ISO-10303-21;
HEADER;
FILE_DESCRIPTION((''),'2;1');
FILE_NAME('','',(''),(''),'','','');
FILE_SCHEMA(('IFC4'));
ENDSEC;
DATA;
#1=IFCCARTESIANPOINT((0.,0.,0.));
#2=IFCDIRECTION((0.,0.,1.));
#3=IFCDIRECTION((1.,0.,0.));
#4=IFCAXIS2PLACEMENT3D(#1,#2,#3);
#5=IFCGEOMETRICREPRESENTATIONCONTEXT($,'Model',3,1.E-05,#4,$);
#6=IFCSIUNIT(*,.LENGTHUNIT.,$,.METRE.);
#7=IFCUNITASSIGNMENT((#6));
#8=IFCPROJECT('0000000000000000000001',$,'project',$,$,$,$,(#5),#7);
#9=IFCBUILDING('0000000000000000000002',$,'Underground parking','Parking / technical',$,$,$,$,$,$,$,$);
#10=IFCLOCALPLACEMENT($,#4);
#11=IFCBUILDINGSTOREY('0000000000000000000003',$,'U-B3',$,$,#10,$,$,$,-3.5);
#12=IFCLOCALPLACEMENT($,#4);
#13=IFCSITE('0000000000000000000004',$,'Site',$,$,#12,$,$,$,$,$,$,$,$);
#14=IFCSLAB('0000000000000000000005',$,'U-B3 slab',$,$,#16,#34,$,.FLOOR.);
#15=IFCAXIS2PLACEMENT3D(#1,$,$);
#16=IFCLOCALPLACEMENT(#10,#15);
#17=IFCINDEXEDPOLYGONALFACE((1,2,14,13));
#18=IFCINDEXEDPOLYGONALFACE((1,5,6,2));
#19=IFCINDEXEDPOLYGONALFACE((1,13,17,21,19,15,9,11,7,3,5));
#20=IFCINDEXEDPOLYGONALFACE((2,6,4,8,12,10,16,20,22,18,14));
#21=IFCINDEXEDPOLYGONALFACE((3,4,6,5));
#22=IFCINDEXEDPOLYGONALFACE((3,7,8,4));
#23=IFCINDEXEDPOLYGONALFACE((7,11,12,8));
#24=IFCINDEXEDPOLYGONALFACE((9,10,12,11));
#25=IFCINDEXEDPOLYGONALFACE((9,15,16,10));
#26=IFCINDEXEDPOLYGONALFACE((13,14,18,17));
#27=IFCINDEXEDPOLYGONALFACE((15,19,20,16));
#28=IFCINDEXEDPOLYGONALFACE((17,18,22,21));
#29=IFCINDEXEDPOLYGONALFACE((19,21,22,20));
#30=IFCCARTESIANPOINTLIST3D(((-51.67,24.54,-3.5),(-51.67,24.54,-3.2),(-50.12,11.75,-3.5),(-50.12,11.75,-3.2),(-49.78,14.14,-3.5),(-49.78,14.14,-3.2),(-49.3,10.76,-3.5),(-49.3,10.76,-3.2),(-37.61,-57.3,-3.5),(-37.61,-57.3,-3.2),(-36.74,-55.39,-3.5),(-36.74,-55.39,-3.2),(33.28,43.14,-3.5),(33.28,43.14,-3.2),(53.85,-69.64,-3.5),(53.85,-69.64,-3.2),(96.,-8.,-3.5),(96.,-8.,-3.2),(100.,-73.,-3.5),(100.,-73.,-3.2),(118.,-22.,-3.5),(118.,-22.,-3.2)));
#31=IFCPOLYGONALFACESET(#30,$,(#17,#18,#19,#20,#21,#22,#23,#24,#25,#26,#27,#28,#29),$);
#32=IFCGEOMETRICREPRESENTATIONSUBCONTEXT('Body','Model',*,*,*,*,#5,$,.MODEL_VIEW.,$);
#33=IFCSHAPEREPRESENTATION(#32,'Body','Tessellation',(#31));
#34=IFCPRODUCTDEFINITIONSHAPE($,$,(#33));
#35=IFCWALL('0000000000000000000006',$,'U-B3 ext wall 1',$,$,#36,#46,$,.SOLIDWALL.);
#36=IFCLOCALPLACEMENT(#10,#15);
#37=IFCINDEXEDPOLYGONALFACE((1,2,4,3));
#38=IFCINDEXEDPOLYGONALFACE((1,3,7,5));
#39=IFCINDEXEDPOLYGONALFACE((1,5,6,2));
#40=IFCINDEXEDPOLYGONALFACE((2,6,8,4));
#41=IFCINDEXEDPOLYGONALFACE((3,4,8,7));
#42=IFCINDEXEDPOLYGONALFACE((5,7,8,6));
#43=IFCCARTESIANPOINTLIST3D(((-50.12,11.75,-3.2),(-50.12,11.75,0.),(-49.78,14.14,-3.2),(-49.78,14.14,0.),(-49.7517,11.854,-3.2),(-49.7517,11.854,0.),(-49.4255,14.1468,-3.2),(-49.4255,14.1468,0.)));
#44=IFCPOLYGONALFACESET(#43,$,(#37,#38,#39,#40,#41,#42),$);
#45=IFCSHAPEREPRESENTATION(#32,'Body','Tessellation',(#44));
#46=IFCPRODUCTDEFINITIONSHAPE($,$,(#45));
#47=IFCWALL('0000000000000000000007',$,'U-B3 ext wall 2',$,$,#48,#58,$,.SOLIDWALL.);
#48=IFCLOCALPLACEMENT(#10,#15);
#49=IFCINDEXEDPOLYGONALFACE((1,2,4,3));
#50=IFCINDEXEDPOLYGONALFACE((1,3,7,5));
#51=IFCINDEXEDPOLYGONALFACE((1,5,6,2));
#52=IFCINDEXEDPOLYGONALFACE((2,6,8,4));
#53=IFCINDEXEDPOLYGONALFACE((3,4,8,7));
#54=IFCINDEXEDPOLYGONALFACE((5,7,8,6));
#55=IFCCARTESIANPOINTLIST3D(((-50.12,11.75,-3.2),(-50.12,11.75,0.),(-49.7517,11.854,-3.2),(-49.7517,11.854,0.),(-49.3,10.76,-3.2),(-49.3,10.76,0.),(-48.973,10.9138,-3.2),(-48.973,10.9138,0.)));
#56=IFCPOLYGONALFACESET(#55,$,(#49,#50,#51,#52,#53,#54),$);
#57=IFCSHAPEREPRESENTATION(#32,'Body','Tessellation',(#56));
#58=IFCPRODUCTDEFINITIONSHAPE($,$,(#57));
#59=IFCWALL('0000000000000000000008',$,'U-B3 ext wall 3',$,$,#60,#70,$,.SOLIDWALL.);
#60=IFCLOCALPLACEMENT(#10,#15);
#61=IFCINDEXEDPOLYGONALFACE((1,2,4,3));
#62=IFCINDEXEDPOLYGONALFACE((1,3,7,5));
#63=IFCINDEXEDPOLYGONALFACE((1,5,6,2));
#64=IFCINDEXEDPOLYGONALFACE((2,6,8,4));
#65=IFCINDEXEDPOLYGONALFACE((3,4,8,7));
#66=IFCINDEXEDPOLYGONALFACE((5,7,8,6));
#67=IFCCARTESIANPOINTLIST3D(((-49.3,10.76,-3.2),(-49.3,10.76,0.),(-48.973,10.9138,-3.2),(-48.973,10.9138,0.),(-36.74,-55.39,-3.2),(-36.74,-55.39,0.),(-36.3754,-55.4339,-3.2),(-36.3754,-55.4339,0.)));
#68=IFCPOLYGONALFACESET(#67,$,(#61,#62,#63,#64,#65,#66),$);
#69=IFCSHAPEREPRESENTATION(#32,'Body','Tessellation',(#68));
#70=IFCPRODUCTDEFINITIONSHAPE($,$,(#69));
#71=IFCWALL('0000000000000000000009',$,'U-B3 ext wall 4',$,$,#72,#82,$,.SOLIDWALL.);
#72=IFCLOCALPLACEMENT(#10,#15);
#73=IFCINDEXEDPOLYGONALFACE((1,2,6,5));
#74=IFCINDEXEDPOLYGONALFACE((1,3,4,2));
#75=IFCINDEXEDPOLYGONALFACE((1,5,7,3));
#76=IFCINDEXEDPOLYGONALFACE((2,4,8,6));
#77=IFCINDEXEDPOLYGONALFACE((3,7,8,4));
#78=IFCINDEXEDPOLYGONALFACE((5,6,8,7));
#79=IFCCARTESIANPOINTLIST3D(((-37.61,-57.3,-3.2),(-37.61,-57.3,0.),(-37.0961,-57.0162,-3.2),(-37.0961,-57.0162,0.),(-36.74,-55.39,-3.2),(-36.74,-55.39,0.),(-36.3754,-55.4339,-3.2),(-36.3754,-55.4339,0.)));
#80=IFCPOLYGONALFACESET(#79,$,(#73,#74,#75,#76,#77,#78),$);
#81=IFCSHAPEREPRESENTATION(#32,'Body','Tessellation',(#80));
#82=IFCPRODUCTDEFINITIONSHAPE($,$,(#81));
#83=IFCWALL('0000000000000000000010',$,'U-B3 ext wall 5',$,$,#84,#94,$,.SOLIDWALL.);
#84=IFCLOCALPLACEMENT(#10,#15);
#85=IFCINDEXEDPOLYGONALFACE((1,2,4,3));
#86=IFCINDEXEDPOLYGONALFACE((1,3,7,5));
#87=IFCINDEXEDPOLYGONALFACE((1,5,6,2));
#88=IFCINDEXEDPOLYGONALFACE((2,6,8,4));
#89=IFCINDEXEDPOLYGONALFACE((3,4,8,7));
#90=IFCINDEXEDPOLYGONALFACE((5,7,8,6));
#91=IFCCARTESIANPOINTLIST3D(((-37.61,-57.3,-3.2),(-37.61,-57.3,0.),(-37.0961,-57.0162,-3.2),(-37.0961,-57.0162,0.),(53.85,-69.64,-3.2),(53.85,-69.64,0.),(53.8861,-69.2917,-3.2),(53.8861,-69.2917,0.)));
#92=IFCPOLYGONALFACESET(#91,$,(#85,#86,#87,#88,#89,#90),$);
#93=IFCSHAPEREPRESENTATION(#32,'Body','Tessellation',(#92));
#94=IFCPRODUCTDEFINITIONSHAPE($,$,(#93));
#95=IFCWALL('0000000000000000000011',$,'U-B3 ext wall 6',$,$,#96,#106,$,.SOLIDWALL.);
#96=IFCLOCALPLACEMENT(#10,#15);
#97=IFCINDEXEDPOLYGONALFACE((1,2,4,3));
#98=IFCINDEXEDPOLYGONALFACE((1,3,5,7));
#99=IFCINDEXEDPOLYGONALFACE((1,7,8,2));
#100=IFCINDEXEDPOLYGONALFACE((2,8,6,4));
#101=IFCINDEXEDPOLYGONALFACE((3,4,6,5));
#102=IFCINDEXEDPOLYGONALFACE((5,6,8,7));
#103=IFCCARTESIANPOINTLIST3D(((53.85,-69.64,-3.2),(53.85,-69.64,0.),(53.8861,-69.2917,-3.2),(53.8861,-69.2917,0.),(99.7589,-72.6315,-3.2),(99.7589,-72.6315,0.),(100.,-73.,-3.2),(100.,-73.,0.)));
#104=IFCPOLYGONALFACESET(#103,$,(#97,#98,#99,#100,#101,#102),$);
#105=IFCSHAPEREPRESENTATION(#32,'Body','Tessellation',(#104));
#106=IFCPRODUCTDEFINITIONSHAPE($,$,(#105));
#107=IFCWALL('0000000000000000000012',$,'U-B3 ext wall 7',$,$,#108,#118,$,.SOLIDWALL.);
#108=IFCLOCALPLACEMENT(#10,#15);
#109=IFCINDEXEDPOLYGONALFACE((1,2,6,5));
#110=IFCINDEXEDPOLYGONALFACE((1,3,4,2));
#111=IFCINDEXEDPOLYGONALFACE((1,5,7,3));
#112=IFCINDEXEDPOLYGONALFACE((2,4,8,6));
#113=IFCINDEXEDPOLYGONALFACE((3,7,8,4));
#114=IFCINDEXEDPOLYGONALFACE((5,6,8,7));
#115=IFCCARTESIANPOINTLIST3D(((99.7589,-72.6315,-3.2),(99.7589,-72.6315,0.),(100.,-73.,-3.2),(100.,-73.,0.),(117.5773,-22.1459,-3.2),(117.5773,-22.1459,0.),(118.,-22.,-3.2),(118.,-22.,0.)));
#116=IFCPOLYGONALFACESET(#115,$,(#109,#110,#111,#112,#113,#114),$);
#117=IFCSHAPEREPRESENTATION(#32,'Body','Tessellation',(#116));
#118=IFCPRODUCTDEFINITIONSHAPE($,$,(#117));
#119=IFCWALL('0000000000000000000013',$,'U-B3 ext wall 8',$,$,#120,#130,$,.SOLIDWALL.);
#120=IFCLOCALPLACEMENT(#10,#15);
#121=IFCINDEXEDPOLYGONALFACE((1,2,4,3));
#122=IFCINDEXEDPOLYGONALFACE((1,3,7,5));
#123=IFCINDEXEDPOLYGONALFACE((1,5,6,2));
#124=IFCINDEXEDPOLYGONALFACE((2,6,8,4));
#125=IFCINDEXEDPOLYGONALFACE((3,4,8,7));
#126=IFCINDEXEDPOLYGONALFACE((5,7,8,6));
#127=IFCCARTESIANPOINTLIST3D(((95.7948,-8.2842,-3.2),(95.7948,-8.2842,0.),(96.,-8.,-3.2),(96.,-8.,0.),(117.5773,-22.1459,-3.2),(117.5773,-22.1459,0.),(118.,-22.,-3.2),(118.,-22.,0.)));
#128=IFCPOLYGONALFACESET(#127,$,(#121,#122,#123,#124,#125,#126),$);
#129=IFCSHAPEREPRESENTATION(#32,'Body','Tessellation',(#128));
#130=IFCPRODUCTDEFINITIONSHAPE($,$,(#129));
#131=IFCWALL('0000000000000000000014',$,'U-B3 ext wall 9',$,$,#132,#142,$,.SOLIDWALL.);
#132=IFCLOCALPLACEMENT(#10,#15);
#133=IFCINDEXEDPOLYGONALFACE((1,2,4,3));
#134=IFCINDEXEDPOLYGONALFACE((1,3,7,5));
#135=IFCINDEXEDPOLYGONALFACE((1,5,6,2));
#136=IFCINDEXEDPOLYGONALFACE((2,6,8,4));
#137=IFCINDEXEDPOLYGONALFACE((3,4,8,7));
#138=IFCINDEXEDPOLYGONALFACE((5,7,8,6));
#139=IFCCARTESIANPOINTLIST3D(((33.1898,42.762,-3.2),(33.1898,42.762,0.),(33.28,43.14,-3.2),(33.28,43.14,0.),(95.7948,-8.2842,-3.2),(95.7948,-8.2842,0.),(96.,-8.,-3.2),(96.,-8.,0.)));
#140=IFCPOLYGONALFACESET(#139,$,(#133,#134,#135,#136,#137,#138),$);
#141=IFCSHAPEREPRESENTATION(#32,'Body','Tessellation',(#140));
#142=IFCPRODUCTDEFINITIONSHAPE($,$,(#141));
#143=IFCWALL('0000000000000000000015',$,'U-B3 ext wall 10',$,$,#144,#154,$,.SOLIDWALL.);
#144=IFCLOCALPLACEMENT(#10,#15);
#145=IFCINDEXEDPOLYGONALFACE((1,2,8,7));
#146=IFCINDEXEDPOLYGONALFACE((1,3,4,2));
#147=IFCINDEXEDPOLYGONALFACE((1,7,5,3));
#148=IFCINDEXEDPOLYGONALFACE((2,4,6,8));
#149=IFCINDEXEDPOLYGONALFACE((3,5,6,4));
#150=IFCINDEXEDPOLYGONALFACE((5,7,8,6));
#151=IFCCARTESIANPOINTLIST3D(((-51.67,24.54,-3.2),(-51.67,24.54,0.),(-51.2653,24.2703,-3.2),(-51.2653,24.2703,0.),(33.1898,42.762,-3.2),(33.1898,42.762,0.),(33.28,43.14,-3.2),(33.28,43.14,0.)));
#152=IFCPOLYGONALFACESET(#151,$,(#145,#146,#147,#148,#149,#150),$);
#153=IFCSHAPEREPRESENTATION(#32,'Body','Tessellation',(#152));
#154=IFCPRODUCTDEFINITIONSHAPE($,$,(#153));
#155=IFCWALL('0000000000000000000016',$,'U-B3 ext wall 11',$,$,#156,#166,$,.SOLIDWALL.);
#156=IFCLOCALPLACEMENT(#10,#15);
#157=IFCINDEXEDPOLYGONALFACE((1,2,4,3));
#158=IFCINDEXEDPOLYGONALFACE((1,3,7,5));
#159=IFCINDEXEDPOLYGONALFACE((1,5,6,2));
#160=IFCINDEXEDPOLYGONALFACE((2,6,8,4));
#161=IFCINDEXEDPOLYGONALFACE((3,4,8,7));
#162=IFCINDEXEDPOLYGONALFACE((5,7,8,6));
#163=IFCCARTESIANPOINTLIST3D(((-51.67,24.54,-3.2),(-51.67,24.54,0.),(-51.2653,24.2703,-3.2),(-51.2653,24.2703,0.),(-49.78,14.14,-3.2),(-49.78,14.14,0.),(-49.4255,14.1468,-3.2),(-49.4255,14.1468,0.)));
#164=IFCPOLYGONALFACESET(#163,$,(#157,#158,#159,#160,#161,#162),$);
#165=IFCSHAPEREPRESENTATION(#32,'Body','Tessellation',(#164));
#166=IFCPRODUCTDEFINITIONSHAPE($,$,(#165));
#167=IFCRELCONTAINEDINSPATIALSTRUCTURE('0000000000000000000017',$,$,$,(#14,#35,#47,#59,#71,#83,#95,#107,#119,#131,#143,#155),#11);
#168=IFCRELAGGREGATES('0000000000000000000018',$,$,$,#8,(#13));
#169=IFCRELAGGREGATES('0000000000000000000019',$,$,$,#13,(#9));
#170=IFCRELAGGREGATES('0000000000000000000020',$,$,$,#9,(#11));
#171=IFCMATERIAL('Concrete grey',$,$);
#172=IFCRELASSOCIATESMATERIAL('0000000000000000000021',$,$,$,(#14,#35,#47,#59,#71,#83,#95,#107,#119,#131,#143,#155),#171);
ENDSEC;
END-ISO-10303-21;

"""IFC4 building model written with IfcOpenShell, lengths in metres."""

from ifc_helpers import new_model, si_unit, frame, origin_with_axes, place, context, subcontext, project, spatial, polyline, outline, extrude, material, element, save


model = new_model("IFC4")

# Units and contexts
model_context = context("Model", 3, precision=1e-05, world=origin_with_axes())
body_context = subcontext(model_context, "Body", "Model", "MODEL_VIEW")
ifc_project = project(units=[si_unit("LENGTHUNIT", "METRE")], contexts=[model_context])

# Site, building, storey
site_placement = place(None, origin_with_axes())
site = spatial("IfcSite", under=ifc_project, at=site_placement, Name="Site")
building = spatial("IfcBuilding", under=site, Name="Underground parking", Description="Parking / technical")
storey_placement = place(None, origin_with_axes())
storey = spatial("IfcBuildingStorey", under=building, at=storey_placement, Name="U-B3", Elevation=-3.5)

# Slab
ifc_material = material(Name="Concrete grey")
slab_placement = place(storey_placement, origin_with_axes())
element("IfcSlab", 1, at=slab_placement, inside=storey, material=ifc_material, Name="U-B3 slab", PredefinedType="FLOOR", context=body_context, shape_type="SweptSolid", body=[
    extrude(outline(polyline([(-49.78, 14.14), (-50.12, 11.75), (-49.3, 10.76), (-36.74, -55.39), (-37.61, -57.3), (53.85, -69.64), (100.0, -73.0), (118.0, -22.0), (96.0, -8.0), (33.28, 43.14), (-51.67, 24.54), (-49.78, 14.14)])), frame((0.0, 0.0, -3.5), z_axis=(0.0, 0.0, 1.0), x_axis=(1.0, 0.0, 0.0)), (0.0, 0.0, 1.0), 0.3),
])

# Walls
wall_1_placement = place(storey_placement, origin_with_axes())
element("IfcWall", 2, at=wall_1_placement, inside=storey, material=ifc_material, Name="U-B3 ext wall 1", PredefinedType="SOLIDWALL", context=body_context, shape_type="SweptSolid", body=[
    extrude(outline(polyline([(-49.78, 14.14), (-50.12, 11.75), (-49.7517, 11.854), (-49.4255, 14.1468), (-49.78, 14.14)])), frame((0.0, 0.0, -3.2), z_axis=(0.0, 0.0, 1.0), x_axis=(1.0, 0.0, 0.0)), (0.0, 0.0, 1.0), 3.2),
])
wall_2_placement = place(storey_placement, origin_with_axes())
element("IfcWall", 3, at=wall_2_placement, inside=storey, material=ifc_material, Name="U-B3 ext wall 2", PredefinedType="SOLIDWALL", context=body_context, shape_type="SweptSolid", body=[
    extrude(outline(polyline([(-50.12, 11.75), (-49.3, 10.76), (-48.973, 10.9138), (-49.7517, 11.854), (-50.12, 11.75)])), frame((0.0, 0.0, -3.2), z_axis=(0.0, 0.0, 1.0), x_axis=(1.0, 0.0, 0.0)), (0.0, 0.0, 1.0), 3.2),
])
wall_3_placement = place(storey_placement, origin_with_axes())
element("IfcWall", 4, at=wall_3_placement, inside=storey, material=ifc_material, Name="U-B3 ext wall 3", PredefinedType="SOLIDWALL", context=body_context, shape_type="SweptSolid", body=[
    extrude(outline(polyline([(-49.3, 10.76), (-36.74, -55.39), (-36.3754, -55.4339), (-48.973, 10.9138), (-49.3, 10.76)])), frame((0.0, 0.0, -3.2), z_axis=(0.0, 0.0, 1.0), x_axis=(1.0, 0.0, 0.0)), (0.0, 0.0, 1.0), 3.2),
])
wall_4_placement = place(storey_placement, origin_with_axes())
element("IfcWall", 5, at=wall_4_placement, inside=storey, material=ifc_material, Name="U-B3 ext wall 4", PredefinedType="SOLIDWALL", context=body_context, shape_type="SweptSolid", body=[
    extrude(outline(polyline([(-36.74, -55.39), (-37.61, -57.3), (-37.0961, -57.0162), (-36.3754, -55.4339), (-36.74, -55.39)])), frame((0.0, 0.0, -3.2), z_axis=(0.0, 0.0, 1.0), x_axis=(1.0, 0.0, 0.0)), (0.0, 0.0, 1.0), 3.2),
])
wall_5_placement = place(storey_placement, origin_with_axes())
element("IfcWall", 6, at=wall_5_placement, inside=storey, material=ifc_material, Name="U-B3 ext wall 5", PredefinedType="SOLIDWALL", context=body_context, shape_type="SweptSolid", body=[
    extrude(outline(polyline([(-37.61, -57.3), (53.85, -69.64), (53.8861, -69.2917), (-37.0961, -57.0162), (-37.61, -57.3)])), frame((0.0, 0.0, -3.2), z_axis=(0.0, 0.0, 1.0), x_axis=(1.0, 0.0, 0.0)), (0.0, 0.0, 1.0), 3.2),
])
wall_6_placement = place(storey_placement, origin_with_axes())
element("IfcWall", 7, at=wall_6_placement, inside=storey, material=ifc_material, Name="U-B3 ext wall 6", PredefinedType="SOLIDWALL", context=body_context, shape_type="SweptSolid", body=[
    extrude(outline(polyline([(53.85, -69.64), (100.0, -73.0), (99.7589, -72.6315), (53.8861, -69.2917), (53.85, -69.64)])), frame((0.0, 0.0, -3.2), z_axis=(0.0, 0.0, 1.0), x_axis=(1.0, 0.0, 0.0)), (0.0, 0.0, 1.0), 3.2),
])
wall_7_placement = place(storey_placement, origin_with_axes())
element("IfcWall", 8, at=wall_7_placement, inside=storey, material=ifc_material, Name="U-B3 ext wall 7", PredefinedType="SOLIDWALL", context=body_context, shape_type="SweptSolid", body=[
    extrude(outline(polyline([(100.0, -73.0), (118.0, -22.0), (117.5773, -22.1459), (99.7589, -72.6315), (100.0, -73.0)])), frame((0.0, 0.0, -3.2), z_axis=(0.0, 0.0, 1.0), x_axis=(1.0, 0.0, 0.0)), (0.0, 0.0, 1.0), 3.2),
])
wall_8_placement = place(storey_placement, origin_with_axes())
element("IfcWall", 9, at=wall_8_placement, inside=storey, material=ifc_material, Name="U-B3 ext wall 8", PredefinedType="SOLIDWALL", context=body_context, shape_type="SweptSolid", body=[
    extrude(outline(polyline([(118.0, -22.0), (96.0, -8.0), (95.7948, -8.2842), (117.5773, -22.1459), (118.0, -22.0)])), frame((0.0, 0.0, -3.2), z_axis=(0.0, 0.0, 1.0), x_axis=(1.0, 0.0, 0.0)), (0.0, 0.0, 1.0), 3.2),
])
wall_9_placement = place(storey_placement, origin_with_axes())
element("IfcWall", 10, at=wall_9_placement, inside=storey, material=ifc_material, Name="U-B3 ext wall 9", PredefinedType="SOLIDWALL", context=body_context, shape_type="SweptSolid", body=[
    extrude(outline(polyline([(96.0, -8.0), (33.28, 43.14), (33.1898, 42.762), (95.7948, -8.2842), (96.0, -8.0)])), frame((0.0, 0.0, -3.2), z_axis=(0.0, 0.0, 1.0), x_axis=(1.0, 0.0, 0.0)), (0.0, 0.0, 1.0), 3.2),
])
wall_10_placement = place(storey_placement, origin_with_axes())
element("IfcWall", 11, at=wall_10_placement, inside=storey, material=ifc_material, Name="U-B3 ext wall 10", PredefinedType="SOLIDWALL", context=body_context, shape_type="SweptSolid", body=[
    extrude(outline(polyline([(33.28, 43.14), (-51.67, 24.54), (-51.2653, 24.2703), (33.1898, 42.762), (33.28, 43.14)])), frame((0.0, 0.0, -3.2), z_axis=(0.0, 0.0, 1.0), x_axis=(1.0, 0.0, 0.0)), (0.0, 0.0, 1.0), 3.2),
])
wall_11_placement = place(storey_placement, origin_with_axes())
element("IfcWall", 12, at=wall_11_placement, inside=storey, material=ifc_material, Name="U-B3 ext wall 11", PredefinedType="SOLIDWALL", context=body_context, shape_type="SweptSolid", body=[
    extrude(outline(polyline([(-51.67, 24.54), (-49.78, 14.14), (-49.4255, 14.1468), (-51.2653, 24.2703), (-51.67, 24.54)])), frame((0.0, 0.0, -3.2), z_axis=(0.0, 0.0, 1.0), x_axis=(1.0, 0.0, 0.0)), (0.0, 0.0, 1.0), 3.2),
])

save(model, "model.ifc")
